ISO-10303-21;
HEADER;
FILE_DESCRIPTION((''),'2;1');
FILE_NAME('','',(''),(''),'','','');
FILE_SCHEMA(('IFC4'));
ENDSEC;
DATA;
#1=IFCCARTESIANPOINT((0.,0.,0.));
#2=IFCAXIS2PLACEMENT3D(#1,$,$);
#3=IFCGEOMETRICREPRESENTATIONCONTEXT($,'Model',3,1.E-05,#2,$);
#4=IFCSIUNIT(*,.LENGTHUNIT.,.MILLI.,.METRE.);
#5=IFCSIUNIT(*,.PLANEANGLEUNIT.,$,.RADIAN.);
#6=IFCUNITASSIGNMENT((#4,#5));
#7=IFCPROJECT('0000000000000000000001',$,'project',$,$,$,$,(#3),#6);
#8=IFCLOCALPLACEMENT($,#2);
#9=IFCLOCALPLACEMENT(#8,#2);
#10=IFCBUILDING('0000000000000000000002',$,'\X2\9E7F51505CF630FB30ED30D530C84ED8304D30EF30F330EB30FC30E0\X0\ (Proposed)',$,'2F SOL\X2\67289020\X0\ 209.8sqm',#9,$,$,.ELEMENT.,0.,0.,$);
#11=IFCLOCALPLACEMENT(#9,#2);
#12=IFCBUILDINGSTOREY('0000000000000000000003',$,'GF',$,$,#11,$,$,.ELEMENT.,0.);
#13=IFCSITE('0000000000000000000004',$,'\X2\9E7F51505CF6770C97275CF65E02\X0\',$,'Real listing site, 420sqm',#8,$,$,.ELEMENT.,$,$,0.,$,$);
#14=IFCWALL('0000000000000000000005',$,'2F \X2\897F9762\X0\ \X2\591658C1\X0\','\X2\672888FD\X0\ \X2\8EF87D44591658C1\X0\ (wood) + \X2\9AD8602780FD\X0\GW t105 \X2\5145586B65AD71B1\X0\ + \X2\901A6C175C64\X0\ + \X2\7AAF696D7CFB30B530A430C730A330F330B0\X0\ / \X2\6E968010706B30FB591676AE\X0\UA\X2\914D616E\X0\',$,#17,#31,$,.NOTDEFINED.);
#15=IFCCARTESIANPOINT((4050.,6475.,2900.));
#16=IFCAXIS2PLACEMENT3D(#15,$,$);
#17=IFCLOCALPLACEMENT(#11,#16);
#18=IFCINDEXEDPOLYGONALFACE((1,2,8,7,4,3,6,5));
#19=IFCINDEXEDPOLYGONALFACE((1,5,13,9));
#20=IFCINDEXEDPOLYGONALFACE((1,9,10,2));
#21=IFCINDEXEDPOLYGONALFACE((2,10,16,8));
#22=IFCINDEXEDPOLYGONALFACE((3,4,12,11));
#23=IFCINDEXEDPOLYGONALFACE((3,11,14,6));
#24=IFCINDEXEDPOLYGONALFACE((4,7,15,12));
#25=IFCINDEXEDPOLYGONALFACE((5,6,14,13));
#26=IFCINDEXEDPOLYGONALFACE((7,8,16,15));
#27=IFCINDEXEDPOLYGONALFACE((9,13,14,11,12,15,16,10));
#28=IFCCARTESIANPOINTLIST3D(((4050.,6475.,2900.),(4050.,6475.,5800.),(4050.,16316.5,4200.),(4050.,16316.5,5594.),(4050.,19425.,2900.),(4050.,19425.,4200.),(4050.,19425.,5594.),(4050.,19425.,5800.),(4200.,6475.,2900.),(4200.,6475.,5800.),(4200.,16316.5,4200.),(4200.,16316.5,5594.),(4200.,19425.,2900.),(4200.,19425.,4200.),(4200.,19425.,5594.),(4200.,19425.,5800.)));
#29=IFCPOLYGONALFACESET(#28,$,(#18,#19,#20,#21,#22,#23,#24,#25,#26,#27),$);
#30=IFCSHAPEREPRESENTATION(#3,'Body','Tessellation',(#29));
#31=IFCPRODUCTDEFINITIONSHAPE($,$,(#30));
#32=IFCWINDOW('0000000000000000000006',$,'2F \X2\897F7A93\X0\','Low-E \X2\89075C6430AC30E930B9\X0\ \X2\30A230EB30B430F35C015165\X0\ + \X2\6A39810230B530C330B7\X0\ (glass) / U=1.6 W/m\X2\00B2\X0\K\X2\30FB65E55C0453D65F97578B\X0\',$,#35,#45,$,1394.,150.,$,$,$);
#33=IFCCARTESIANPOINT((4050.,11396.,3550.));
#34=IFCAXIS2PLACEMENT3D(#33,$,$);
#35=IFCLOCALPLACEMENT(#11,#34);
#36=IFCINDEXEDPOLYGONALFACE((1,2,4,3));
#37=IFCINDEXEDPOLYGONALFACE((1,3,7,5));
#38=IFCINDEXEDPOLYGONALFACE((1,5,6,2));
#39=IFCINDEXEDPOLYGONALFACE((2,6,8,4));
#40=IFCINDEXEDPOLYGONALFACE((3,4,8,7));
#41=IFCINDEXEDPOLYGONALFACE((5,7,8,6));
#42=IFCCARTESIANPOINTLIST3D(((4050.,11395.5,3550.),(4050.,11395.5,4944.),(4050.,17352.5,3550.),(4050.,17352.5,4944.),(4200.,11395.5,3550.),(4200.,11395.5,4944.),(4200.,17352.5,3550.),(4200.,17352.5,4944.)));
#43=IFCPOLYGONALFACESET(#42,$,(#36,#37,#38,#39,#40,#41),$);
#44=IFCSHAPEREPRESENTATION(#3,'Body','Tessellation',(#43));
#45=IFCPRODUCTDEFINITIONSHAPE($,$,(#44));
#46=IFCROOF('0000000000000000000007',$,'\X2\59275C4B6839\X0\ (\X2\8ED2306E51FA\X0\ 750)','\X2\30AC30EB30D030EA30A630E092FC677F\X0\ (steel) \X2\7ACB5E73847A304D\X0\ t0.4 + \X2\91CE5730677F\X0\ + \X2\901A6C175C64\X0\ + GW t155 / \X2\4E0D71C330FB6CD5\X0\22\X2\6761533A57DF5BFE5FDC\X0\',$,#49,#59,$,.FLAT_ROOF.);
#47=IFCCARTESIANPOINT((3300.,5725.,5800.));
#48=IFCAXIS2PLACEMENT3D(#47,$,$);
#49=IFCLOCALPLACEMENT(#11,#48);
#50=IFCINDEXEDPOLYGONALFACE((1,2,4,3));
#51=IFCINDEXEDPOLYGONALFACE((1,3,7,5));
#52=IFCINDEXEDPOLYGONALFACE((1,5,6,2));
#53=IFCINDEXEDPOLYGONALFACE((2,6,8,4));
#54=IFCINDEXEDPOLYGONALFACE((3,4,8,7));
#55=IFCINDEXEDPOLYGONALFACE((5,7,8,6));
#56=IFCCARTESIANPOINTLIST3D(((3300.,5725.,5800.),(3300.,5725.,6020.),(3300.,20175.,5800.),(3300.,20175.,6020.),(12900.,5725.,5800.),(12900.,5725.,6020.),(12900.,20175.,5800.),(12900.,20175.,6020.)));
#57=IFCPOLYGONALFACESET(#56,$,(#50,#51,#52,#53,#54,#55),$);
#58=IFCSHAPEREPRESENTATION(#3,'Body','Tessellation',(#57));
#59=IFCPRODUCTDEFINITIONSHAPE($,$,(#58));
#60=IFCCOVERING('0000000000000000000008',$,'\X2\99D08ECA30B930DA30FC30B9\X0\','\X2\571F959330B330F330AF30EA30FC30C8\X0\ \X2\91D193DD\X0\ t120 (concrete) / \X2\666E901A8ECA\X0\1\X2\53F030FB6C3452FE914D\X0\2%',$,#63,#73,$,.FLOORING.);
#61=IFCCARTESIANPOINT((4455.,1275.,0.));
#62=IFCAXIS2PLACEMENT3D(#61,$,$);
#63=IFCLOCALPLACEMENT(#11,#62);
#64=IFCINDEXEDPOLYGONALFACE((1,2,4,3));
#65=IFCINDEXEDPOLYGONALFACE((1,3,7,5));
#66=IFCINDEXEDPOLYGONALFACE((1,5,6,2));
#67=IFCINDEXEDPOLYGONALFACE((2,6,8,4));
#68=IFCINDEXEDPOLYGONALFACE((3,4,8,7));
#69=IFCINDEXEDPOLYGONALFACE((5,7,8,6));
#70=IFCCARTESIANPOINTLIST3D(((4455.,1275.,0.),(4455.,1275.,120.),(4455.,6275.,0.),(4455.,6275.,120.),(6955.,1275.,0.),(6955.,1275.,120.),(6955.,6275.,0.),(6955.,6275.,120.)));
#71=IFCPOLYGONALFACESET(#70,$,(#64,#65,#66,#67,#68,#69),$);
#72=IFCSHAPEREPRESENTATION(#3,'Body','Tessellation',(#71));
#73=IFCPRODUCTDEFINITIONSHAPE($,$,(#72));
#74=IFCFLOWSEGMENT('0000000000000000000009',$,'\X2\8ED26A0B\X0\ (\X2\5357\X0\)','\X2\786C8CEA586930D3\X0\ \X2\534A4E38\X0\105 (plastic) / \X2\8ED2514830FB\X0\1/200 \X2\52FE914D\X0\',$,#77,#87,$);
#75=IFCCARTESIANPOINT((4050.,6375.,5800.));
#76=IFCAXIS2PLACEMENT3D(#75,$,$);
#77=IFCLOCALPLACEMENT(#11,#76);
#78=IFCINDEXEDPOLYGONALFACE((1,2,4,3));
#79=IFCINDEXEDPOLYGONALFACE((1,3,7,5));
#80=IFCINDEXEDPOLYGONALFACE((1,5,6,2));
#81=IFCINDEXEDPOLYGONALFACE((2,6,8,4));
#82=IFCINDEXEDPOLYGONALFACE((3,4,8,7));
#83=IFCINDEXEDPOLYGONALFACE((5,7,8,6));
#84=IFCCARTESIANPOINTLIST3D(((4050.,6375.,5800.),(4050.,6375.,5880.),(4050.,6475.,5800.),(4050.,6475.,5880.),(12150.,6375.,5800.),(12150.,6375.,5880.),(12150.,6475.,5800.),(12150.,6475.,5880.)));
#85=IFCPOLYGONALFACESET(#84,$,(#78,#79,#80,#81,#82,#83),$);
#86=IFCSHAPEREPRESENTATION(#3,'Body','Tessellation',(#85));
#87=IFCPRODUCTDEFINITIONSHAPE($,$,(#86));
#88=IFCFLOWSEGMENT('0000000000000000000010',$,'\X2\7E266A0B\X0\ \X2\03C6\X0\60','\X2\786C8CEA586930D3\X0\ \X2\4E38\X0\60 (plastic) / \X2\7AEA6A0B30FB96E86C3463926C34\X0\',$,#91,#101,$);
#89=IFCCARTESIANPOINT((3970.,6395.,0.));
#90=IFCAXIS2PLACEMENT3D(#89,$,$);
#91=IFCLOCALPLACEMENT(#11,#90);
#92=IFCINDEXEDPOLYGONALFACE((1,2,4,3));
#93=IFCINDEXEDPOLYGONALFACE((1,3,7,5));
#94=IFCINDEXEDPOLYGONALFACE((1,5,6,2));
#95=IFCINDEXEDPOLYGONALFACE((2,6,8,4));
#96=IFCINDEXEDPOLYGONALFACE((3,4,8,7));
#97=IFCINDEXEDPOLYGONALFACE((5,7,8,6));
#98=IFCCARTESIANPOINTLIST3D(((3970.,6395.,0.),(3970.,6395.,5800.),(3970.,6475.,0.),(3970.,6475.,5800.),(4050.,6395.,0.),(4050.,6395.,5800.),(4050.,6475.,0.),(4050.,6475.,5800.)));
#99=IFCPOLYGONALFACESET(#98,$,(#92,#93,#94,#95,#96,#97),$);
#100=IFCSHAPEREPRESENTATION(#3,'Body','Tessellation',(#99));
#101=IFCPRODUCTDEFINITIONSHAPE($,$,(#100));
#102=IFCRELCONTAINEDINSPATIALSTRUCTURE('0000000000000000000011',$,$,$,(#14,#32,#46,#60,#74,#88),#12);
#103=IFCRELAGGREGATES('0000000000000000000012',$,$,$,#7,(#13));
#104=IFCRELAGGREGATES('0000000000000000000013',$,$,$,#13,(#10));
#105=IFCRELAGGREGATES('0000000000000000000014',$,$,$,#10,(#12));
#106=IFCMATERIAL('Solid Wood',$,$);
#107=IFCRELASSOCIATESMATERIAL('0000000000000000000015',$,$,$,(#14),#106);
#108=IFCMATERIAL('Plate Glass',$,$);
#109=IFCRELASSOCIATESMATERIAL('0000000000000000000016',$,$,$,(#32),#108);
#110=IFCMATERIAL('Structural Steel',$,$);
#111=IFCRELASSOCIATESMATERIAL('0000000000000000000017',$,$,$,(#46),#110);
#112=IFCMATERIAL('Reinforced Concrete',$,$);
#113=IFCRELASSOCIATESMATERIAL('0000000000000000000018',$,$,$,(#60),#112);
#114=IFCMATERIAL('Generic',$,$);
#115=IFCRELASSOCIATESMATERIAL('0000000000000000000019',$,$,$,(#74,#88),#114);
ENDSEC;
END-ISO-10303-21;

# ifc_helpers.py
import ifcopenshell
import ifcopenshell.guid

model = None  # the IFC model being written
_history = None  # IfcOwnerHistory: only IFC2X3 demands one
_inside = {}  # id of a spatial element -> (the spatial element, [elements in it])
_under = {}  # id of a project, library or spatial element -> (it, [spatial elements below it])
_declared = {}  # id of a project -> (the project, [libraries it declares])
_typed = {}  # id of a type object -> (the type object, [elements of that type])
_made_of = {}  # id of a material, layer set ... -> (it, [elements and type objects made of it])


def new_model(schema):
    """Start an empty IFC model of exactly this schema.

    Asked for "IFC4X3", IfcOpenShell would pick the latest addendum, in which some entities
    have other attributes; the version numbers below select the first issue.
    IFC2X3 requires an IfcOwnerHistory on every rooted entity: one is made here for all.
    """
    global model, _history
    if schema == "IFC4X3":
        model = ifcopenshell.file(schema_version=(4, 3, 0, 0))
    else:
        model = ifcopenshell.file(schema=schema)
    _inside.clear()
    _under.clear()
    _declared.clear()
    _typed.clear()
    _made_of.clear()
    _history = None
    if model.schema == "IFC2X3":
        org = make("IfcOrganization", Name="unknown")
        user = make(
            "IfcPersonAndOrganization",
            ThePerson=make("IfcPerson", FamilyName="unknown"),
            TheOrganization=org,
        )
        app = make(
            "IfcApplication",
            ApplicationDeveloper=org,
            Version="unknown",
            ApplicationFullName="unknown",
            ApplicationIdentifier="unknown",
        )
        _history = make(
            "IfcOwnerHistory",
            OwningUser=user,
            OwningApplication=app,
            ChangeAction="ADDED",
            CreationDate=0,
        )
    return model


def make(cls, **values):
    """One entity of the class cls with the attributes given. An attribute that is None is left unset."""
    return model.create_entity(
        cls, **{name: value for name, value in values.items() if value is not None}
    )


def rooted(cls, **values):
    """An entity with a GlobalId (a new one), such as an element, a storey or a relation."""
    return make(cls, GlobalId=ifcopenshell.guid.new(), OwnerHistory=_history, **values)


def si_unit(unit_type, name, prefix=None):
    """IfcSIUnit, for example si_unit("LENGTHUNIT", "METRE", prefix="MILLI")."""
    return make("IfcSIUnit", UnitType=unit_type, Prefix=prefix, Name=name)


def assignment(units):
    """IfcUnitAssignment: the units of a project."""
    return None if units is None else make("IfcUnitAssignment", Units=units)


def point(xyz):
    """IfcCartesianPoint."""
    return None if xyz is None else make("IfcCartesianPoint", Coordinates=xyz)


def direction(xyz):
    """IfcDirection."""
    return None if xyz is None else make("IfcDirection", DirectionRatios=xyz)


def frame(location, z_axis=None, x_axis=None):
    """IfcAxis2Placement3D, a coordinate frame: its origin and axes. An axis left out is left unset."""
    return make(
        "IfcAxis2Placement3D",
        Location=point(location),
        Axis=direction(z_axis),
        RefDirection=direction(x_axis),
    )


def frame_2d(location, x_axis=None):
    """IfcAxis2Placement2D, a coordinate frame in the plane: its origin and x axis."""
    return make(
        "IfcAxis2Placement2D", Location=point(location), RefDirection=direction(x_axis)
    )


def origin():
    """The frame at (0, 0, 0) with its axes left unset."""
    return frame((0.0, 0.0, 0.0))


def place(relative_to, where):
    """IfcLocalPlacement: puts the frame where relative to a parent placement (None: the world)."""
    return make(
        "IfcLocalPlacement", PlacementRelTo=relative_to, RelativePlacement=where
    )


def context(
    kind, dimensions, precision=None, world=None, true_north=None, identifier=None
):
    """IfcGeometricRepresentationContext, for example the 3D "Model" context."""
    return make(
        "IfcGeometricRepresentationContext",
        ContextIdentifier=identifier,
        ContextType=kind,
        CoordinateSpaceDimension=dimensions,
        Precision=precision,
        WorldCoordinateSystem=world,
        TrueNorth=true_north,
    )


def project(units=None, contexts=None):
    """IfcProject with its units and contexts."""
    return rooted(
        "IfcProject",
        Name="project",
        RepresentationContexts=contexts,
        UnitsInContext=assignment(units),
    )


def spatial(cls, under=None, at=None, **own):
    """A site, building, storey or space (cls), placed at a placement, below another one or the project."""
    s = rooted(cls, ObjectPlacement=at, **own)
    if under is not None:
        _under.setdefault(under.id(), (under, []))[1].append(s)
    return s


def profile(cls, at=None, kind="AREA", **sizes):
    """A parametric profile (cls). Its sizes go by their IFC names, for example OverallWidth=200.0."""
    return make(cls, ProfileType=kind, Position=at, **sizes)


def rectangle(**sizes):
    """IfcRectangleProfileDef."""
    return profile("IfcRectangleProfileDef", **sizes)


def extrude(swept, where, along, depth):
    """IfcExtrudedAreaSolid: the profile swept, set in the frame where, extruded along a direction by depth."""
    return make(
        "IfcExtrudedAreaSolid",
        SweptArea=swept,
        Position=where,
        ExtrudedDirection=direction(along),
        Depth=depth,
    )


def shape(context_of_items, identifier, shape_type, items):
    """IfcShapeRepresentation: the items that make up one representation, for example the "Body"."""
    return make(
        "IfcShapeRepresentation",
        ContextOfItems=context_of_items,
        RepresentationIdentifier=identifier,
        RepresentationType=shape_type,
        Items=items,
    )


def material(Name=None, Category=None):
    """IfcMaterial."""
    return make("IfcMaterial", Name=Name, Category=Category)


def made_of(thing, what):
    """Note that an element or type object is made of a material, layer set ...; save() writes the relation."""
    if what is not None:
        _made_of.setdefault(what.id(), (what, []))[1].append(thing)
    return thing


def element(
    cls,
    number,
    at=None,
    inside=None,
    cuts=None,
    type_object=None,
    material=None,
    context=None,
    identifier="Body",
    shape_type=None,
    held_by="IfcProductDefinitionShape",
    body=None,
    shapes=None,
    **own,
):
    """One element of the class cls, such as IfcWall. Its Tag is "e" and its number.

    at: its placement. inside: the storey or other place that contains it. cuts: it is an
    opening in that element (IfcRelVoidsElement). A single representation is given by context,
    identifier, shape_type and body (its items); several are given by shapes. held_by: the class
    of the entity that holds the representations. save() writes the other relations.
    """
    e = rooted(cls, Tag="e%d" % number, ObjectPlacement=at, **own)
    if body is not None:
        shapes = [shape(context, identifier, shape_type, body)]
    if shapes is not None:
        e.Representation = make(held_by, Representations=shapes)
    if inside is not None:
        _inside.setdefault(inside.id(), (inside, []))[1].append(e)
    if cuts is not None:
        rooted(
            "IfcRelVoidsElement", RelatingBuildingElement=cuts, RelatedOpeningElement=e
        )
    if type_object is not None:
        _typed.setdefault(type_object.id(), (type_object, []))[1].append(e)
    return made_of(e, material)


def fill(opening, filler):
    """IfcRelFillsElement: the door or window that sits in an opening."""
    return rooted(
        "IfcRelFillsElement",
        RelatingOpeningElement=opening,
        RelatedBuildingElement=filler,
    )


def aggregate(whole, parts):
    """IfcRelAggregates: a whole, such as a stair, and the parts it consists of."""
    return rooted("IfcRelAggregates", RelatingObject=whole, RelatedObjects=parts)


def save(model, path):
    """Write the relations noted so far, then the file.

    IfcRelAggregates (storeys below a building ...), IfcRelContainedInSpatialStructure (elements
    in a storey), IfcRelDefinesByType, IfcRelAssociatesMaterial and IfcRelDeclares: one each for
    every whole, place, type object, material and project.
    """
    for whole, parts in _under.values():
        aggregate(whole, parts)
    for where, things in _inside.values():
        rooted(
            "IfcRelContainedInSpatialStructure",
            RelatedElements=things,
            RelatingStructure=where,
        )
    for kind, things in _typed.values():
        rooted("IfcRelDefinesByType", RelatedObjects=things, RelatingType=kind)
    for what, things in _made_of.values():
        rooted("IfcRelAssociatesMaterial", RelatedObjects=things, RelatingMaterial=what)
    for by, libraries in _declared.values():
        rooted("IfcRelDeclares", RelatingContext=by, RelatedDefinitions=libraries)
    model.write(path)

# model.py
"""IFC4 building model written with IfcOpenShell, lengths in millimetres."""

from ifc_helpers import new_model, si_unit, frame, frame_2d, origin, place, context, project, spatial, rectangle, extrude, material, element, fill, save


model = new_model("IFC4")

# Units and contexts
model_context = context("Model", 3, precision=1e-05, world=origin())
ifc_project = project(units=[si_unit("LENGTHUNIT", "METRE", prefix="MILLI"), si_unit("PLANEANGLEUNIT", "RADIAN")], contexts=[model_context])

# Site, building, storey
site_placement = place(None, origin())
site = spatial("IfcSite", under=ifc_project, at=site_placement, Name="鹿児島県霧島市", ObjectType="Real listing site, 420sqm", CompositionType="ELEMENT", RefElevation=0.0)
building_placement = place(site_placement, origin())
building = spatial("IfcBuilding", under=site, at=building_placement, Name="鹿児島・ロフト付きワンルーム (Proposed)", ObjectType="2F SOL木造 209.8sqm", CompositionType="ELEMENT", ElevationOfRefHeight=0.0, ElevationOfTerrain=0.0)
storey_placement = place(building_placement, origin())
storey = spatial("IfcBuildingStorey", under=building, at=storey_placement, Name="GF", CompositionType="ELEMENT", Elevation=0.0)

# Shared definitions
ifc_material_1 = material(Name="Solid Wood")

# Shared definitions
ifc_material_2 = material(Name="Reinforced Concrete")

# Shared definitions
ifc_material_3 = material(Name="Plate Glass")

# Wall, opening, window
wall_1_placement = place(storey_placement, frame((4050.0, 6475.0, 2900.0)))
wall_1 = element("IfcWall", 1, at=wall_1_placement, inside=storey, material=ifc_material_1, Name="2F 西面 外壁", Description="木製 軸組外壁 (wood) + 高性能GW t105 充填断熱 + 通気層 + 窯業系サイディング / 準耐火・外皮UA配慮", PredefinedType="NOTDEFINED", context=model_context, shape_type="SweptSolid", body=[
    extrude(rectangle(XDim=150.0, YDim=12950.0, at=frame_2d((75.0, 6475.0))), frame((4050.0, 6475.0, 2900.0)), (0.0, 0.0, 1.0), 2900.0),
])
opening_1_placement = place(storey_placement, frame((4050.0, 11396.0, 3550.0)))
opening_1 = element("IfcOpeningElement", 2, at=opening_1_placement, cuts=wall_1, PredefinedType="NOTDEFINED", context=model_context, shape_type="SweptSolid", body=[
    extrude(rectangle(XDim=150.0, YDim=5957.0, at=frame_2d((75.0, 2978.0))), frame((4050.0, 11396.0, 3550.0)), (0.0, 0.0, 1.0), 1394.0),
])
window_1_placement = place(storey_placement, frame((4050.0, 11396.0, 3550.0)))
window_1 = element("IfcWindow", 3, at=window_1_placement, inside=storey, material=ifc_material_3, Name="2F 西窓", Description="Low-E 複層ガラス アルゴン封入 + 樹脂サッシ (glass) / U=1.6 W/m²K・日射取得型", OverallHeight=1394.0, OverallWidth=150.0, context=model_context, shape_type="SweptSolid", body=[
    extrude(rectangle(XDim=150.0, YDim=5957.0, at=frame_2d((75.0, 2978.0))), frame((4050.0, 11396.0, 3550.0)), (0.0, 0.0, 1.0), 1394.0),
])
fill(opening_1, window_1)

# Roof
ifc_material_4 = material(Name="Structural Steel")
roof_placement = place(storey_placement, frame((3300.0, 5725.0, 5800.0)))
element("IfcRoof", 4, at=roof_placement, inside=storey, material=ifc_material_4, Name="大屋根 (軒の出 750)", Description="ガルバリウム鋼板 (steel) 立平葺き t0.4 + 野地板 + 通気層 + GW t155 / 不燃・法22条区域対応", PredefinedType="FLAT_ROOF", context=model_context, shape_type="SweptSolid", body=[
    extrude(rectangle(XDim=9600.0, YDim=14450.0, at=frame_2d((4800.0, 7225.0))), frame((3300.0, 5725.0, 5800.0)), (0.0, 0.0, 1.0), 220.0),
])

# Covering
covering_placement = place(storey_placement, frame((4455.0, 1275.0, 0.0)))
element("IfcCovering", 5, at=covering_placement, inside=storey, material=ifc_material_2, Name="駐車スペース", Description="土間コンクリート 金鏝 t120 (concrete) / 普通車1台・水勾配2%", PredefinedType="FLOORING", context=model_context, shape_type="SweptSolid", body=[
    extrude(rectangle(XDim=2500.0, YDim=5000.0, at=frame_2d((1250.0, 2500.0))), frame((4455.0, 1275.0, 0.0)), (0.0, 0.0, 1.0), 120.0),
])

# Flow segments
ifc_material_5 = material(Name="Generic")
flow_segment_1_placement = place(storey_placement, frame((4050.0, 6375.0, 5800.0)))
element("IfcFlowSegment", 6, at=flow_segment_1_placement, inside=storey, material=ifc_material_5, Name="軒樋 (南)", Description="硬質塩ビ 半丸105 (plastic) / 軒先・1/200 勾配", context=model_context, shape_type="SweptSolid", body=[
    extrude(rectangle(XDim=8100.0, YDim=100.0, at=frame_2d((4050.0, 50.0))), frame((4050.0, 6375.0, 5800.0)), (0.0, 0.0, 1.0), 80.0),
])
flow_segment_2_placement = place(storey_placement, frame((3970.0, 6395.0, 0.0)))
element("IfcFlowSegment", 7, at=flow_segment_2_placement, inside=storey, material=ifc_material_5, Name="縦樋 φ60", Description="硬質塩ビ 丸60 (plastic) / 竪樋・雨水排水", context=model_context, shape_type="SweptSolid", body=[
    extrude(rectangle(XDim=80.0, YDim=80.0, at=frame_2d((40.0, 40.0))), frame((3970.0, 6395.0, 0.0)), (0.0, 0.0, 1.0), 5800.0),
])

save(model, "model.ifc")
